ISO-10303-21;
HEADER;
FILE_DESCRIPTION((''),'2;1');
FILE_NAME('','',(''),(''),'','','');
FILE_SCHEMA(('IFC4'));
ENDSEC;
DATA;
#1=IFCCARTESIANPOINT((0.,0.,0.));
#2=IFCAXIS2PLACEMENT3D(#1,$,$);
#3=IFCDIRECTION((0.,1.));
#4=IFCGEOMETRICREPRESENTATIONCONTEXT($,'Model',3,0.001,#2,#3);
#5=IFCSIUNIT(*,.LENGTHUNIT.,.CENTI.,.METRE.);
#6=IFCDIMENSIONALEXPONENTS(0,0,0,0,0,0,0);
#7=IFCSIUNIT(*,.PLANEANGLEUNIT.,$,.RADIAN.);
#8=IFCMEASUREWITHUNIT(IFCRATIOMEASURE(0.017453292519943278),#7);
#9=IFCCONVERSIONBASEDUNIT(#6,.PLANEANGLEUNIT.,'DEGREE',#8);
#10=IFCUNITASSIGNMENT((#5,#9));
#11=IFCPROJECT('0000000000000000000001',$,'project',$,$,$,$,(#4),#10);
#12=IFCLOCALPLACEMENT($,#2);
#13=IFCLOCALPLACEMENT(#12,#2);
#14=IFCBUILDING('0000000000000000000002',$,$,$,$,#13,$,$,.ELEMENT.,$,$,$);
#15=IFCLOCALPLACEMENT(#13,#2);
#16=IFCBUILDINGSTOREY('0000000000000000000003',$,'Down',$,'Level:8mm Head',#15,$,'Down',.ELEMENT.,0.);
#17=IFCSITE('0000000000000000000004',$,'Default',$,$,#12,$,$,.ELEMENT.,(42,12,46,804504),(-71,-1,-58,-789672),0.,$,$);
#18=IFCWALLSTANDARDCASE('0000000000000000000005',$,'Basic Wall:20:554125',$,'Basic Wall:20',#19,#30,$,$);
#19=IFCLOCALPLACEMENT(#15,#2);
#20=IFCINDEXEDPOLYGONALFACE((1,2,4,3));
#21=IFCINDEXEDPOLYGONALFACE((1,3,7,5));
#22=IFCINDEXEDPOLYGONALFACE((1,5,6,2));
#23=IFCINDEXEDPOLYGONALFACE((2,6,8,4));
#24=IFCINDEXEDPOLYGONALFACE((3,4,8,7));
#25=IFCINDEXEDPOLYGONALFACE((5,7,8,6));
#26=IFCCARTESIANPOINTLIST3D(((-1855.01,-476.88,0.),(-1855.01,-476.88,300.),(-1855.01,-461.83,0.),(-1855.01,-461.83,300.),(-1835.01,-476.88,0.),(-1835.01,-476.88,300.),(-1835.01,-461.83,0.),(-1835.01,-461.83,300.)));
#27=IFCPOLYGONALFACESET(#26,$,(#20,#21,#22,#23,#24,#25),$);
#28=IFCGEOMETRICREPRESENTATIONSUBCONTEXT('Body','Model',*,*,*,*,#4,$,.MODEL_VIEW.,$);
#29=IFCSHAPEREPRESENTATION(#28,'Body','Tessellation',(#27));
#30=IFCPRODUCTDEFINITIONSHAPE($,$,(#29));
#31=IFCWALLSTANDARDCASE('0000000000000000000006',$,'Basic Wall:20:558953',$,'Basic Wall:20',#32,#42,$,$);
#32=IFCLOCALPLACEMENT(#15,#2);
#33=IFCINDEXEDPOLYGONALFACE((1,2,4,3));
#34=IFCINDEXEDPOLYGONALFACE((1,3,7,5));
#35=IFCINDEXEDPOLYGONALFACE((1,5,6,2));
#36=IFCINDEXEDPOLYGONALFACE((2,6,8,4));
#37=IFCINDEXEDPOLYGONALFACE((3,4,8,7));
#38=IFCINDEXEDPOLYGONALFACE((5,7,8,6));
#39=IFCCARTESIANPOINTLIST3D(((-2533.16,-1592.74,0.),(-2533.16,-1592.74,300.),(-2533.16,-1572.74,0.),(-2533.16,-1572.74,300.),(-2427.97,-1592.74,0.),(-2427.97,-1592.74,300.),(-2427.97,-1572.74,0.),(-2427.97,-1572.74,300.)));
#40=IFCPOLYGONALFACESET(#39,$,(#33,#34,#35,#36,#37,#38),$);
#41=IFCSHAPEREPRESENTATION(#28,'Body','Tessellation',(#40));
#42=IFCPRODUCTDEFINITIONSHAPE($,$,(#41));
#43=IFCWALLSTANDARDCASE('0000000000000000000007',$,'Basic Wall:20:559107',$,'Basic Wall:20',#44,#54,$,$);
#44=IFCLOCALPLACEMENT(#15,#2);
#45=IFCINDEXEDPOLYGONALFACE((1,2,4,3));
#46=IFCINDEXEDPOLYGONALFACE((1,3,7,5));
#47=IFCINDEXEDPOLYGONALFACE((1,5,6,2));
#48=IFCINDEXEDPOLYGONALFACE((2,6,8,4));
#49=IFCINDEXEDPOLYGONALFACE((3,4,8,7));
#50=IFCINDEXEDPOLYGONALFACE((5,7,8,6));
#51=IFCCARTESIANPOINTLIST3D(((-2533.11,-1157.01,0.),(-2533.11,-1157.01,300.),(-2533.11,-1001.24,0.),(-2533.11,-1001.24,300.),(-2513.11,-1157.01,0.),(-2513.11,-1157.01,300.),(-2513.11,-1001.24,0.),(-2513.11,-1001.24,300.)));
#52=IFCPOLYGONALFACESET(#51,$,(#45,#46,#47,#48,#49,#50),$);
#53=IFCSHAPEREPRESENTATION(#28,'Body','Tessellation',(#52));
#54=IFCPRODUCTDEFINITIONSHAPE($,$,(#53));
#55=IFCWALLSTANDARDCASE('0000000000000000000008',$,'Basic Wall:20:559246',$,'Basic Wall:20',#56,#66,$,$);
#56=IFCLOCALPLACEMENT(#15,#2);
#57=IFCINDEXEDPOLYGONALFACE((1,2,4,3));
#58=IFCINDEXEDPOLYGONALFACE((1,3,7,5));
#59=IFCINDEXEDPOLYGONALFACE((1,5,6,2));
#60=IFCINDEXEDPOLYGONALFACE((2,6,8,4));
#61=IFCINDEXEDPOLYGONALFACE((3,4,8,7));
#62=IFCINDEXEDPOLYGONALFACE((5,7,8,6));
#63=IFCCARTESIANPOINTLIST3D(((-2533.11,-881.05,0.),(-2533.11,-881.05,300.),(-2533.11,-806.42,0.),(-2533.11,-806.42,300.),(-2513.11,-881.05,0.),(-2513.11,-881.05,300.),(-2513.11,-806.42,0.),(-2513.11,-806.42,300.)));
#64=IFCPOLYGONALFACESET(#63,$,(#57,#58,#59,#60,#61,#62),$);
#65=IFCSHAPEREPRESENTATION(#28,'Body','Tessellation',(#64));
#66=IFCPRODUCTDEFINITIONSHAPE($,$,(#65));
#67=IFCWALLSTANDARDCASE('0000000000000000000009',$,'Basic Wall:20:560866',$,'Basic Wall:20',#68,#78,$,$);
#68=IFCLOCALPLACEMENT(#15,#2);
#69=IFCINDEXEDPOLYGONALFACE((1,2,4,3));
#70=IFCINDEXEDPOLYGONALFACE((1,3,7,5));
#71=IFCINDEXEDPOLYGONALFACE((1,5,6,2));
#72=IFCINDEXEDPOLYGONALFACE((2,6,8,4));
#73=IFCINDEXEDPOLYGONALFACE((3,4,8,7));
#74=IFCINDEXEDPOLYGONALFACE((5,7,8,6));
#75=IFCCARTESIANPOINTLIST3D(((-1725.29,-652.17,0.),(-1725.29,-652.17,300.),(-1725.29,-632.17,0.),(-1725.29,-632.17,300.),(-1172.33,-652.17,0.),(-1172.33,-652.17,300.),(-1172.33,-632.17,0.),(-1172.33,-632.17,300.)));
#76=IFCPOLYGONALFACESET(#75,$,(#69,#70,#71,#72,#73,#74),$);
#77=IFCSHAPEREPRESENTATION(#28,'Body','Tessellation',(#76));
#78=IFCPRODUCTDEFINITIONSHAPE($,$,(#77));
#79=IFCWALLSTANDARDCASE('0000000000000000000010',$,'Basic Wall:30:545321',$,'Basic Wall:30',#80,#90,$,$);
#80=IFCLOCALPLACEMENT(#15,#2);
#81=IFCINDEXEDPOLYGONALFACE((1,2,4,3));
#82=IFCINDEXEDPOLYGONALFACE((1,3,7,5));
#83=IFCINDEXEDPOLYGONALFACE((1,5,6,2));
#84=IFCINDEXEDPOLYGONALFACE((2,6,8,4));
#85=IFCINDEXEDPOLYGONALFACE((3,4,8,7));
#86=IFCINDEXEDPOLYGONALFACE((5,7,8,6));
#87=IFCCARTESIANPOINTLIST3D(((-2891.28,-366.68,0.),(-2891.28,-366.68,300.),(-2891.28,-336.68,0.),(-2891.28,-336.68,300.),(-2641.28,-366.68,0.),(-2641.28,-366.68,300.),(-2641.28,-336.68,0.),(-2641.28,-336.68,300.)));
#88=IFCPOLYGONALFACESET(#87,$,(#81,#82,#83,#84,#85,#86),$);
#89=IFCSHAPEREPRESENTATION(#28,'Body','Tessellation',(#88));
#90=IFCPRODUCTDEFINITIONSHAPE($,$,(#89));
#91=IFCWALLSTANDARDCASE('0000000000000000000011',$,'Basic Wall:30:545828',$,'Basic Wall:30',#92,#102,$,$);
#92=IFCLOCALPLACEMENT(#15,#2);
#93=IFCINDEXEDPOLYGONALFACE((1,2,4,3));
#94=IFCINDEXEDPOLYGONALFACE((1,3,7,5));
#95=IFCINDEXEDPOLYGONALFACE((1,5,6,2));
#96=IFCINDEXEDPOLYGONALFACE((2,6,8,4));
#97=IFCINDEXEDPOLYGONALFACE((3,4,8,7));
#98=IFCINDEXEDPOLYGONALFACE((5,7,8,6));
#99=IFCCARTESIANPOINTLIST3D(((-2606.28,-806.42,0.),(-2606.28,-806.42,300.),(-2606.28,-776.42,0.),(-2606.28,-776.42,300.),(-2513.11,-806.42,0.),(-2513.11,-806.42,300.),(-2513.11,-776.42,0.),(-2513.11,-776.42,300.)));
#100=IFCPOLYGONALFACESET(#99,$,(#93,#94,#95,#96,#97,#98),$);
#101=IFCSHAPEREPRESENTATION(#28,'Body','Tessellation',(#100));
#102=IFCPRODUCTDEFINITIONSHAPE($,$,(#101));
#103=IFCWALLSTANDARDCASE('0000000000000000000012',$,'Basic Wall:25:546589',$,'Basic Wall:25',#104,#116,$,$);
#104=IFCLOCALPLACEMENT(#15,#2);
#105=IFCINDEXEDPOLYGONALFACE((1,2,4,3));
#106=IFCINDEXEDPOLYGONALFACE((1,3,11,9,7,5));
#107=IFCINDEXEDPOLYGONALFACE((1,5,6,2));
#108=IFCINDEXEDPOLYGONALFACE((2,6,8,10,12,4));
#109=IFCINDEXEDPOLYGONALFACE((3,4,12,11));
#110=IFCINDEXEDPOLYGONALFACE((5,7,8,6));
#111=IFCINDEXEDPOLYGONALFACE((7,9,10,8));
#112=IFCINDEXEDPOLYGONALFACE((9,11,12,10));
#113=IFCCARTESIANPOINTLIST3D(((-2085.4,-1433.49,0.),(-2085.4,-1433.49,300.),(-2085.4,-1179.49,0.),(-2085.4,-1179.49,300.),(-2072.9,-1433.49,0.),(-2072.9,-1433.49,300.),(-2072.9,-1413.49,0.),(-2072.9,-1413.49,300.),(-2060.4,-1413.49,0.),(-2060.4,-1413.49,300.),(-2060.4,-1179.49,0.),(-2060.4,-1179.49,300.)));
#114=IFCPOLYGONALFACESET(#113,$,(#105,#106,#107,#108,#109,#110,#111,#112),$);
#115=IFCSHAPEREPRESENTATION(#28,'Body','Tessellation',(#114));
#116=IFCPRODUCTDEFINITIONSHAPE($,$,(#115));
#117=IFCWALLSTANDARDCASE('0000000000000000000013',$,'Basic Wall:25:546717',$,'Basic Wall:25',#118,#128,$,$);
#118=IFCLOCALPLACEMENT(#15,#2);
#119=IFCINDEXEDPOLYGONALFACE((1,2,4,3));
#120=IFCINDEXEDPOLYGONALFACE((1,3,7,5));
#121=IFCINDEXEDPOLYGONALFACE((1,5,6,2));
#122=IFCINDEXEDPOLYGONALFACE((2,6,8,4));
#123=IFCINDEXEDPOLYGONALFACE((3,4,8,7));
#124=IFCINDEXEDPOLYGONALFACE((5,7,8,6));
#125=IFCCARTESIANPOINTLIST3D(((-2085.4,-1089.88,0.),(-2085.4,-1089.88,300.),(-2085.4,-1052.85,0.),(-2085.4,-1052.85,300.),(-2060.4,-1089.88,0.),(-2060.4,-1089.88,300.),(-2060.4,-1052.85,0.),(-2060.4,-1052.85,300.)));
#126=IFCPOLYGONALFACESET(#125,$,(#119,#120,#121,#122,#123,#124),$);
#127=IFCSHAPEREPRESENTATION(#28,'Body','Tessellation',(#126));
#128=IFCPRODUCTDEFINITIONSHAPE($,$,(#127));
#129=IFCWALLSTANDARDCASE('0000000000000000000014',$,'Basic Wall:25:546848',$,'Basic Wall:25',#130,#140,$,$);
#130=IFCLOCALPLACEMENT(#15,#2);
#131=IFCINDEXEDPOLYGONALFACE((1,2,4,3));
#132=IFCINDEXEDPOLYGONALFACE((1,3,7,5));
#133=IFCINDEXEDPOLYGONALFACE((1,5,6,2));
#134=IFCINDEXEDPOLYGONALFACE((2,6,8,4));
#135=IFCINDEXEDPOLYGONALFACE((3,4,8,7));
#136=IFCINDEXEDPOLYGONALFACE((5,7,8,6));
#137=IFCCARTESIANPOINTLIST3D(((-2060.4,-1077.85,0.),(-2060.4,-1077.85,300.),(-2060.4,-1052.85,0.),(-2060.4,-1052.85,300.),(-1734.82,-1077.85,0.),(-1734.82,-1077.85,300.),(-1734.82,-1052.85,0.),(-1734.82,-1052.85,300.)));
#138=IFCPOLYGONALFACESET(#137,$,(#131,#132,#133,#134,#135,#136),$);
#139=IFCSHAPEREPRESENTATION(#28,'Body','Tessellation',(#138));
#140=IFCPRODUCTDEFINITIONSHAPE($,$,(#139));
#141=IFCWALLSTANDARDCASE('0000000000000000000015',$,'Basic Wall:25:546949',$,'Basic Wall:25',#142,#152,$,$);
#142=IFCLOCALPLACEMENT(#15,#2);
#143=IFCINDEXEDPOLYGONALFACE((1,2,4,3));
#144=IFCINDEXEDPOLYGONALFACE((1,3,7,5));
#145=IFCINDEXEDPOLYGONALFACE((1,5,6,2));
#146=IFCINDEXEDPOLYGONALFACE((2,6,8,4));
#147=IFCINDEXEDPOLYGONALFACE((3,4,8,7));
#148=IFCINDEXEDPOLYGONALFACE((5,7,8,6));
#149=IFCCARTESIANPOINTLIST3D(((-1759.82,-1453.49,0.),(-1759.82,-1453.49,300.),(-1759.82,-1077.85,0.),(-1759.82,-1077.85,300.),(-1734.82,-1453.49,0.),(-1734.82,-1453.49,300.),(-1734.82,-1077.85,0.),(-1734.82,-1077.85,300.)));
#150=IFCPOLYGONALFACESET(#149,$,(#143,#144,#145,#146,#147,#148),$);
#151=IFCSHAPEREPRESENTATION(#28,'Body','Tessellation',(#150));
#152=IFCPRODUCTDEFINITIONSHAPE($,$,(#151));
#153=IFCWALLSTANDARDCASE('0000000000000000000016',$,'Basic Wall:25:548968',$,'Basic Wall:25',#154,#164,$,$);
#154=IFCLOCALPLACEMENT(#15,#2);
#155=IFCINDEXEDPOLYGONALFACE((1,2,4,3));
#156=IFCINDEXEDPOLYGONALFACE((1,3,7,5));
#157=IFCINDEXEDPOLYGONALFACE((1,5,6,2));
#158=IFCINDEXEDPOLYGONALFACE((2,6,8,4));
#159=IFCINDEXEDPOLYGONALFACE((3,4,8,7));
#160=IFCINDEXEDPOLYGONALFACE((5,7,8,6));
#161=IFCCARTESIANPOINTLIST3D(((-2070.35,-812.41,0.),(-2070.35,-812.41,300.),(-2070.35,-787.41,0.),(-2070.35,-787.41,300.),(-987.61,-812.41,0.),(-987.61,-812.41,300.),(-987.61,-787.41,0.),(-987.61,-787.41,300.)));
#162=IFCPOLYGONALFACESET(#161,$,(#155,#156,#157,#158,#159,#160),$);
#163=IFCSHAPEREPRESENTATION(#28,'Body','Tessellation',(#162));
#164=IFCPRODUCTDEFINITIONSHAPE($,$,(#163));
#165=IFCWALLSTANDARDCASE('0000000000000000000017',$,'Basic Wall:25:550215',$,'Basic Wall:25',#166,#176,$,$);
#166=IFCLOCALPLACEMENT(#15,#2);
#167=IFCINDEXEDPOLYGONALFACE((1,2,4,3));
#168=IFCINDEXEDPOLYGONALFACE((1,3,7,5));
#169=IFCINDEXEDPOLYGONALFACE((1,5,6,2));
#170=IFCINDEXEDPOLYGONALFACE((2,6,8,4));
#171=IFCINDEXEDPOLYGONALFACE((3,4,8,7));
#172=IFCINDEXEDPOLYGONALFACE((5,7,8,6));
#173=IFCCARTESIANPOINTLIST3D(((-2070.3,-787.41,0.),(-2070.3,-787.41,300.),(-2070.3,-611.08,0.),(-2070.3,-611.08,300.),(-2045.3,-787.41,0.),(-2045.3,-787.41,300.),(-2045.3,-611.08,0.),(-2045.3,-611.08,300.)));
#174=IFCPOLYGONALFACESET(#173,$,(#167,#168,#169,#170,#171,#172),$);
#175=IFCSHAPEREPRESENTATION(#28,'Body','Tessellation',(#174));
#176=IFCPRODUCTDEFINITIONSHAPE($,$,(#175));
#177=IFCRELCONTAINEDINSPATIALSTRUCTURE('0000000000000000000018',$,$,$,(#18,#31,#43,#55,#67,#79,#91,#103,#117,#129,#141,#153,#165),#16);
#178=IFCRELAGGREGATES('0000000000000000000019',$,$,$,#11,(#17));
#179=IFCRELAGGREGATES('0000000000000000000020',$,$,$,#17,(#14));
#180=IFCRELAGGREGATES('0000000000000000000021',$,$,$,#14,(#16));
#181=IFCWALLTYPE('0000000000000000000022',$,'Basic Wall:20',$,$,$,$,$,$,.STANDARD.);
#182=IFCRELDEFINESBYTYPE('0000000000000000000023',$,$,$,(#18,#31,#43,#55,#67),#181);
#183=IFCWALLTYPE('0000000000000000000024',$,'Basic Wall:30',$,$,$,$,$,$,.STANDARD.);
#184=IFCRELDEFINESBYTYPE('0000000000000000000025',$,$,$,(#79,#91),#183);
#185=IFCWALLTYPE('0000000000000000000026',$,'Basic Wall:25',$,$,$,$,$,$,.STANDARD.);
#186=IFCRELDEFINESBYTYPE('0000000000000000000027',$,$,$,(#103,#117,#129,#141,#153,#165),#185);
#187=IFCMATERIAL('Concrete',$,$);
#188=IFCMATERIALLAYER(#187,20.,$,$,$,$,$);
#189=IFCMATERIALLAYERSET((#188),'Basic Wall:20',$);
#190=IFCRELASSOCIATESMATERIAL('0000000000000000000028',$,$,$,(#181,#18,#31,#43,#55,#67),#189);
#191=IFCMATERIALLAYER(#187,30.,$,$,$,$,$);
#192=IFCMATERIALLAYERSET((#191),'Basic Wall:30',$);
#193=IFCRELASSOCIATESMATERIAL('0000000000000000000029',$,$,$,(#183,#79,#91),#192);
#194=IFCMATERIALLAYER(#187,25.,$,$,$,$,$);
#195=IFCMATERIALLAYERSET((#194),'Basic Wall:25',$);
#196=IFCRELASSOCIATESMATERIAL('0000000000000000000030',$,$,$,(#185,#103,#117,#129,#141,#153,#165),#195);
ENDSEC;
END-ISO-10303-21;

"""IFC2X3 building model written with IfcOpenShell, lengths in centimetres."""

from ifc_helpers import new_model, entity, si_unit, converted_unit, direction, frame, frame_2d, origin, place, context, subcontext, project, spatial, polyline, rectangle, outline, extrude, material, layer, layer_set, layer_usage, type_object, element, save


model = new_model("IFC2X3")

# Units and contexts
model_context = context("Model", 3, precision=0.001, world=origin(), true_north=direction((0.0, 1.0)))
body_context = subcontext(model_context, "Body", "Model", "MODEL_VIEW")
ifc_project = project(units=[si_unit("LENGTHUNIT", "METRE", prefix="CENTI"), converted_unit("PLANEANGLEUNIT", "DEGREE", entity("IfcRatioMeasure", 0.017453292519943278), si_unit("PLANEANGLEUNIT", "RADIAN"), dimensions=[0, 0, 0, 0, 0, 0, 0])], contexts=[model_context])

# Site, building, storey
site_placement = place(None, origin())
site = spatial("IfcSite", under=ifc_project, at=site_placement, Name="Default", CompositionType="ELEMENT", RefLatitude=(42, 12, 46, 804504), RefLongitude=(-71, -1, -58, -789672), RefElevation=0.0)
building_placement = place(site_placement, origin())
building = spatial("IfcBuilding", under=site, at=building_placement, CompositionType="ELEMENT")
storey_placement = place(building_placement, origin())
storey = spatial("IfcBuildingStorey", under=building, at=storey_placement, Name="Down", ObjectType="Level:8mm Head", LongName="Down", CompositionType="ELEMENT", Elevation=0.0)

# Walls
ifc_material = material(Name="Concrete")
ifc_layer_1 = layer(ifc_material, 20.0)
ifc_layer_set_1 = layer_set([ifc_layer_1], Name="Basic Wall:20")
wall_type_1 = type_object("IfcWallType", Name="Basic Wall:20", PredefinedType="STANDARD", material=ifc_layer_set_1)
ifc_layer_usage_1 = layer_usage(ifc_layer_set_1, "AXIS2", "POSITIVE", -10.0)
wall_1_placement = place(storey_placement, frame((-1845.01, -476.88, 0.0), z_axis=(0.0, 0.0, 1.0), x_axis=(0.0, 1.0, 0.0)))
element("IfcWallStandardCase", 1, at=wall_1_placement, inside=storey, type_object=wall_type_1, material=ifc_layer_usage_1, Name="Basic Wall:20:554125", ObjectType="Basic Wall:20", context=body_context, shape_type="SweptSolid", body=[
    extrude(rectangle(XDim=15.05, YDim=20.0, at=frame_2d((7.53, 0.0), x_axis=(-1.0, 0.0))), origin(), (0.0, 0.0, 1.0), 300.0),
])
ifc_layer_usage_2 = layer_usage(ifc_layer_set_1, "AXIS2", "POSITIVE", -10.0)
wall_2_placement = place(storey_placement, frame((-2533.16, -1582.74, 0.0)))
element("IfcWallStandardCase", 2, at=wall_2_placement, inside=storey, type_object=wall_type_1, material=ifc_layer_usage_2, Name="Basic Wall:20:558953", ObjectType="Basic Wall:20", context=body_context, shape_type="SweptSolid", body=[
    extrude(rectangle(XDim=105.2, YDim=20.0, at=frame_2d((52.6, 0.0), x_axis=(-1.0, 0.0))), origin(), (0.0, 0.0, 1.0), 300.0),
])
ifc_layer_usage_3 = layer_usage(ifc_layer_set_1, "AXIS2", "POSITIVE", -10.0)
wall_3_placement = place(storey_placement, frame((-2523.11, -1157.01, 0.0), z_axis=(0.0, 0.0, 1.0), x_axis=(0.0, 1.0, 0.0)))
element("IfcWallStandardCase", 3, at=wall_3_placement, inside=storey, type_object=wall_type_1, material=ifc_layer_usage_3, Name="Basic Wall:20:559107", ObjectType="Basic Wall:20", context=body_context, shape_type="SweptSolid", body=[
    extrude(rectangle(XDim=155.76, YDim=20.0, at=frame_2d((77.88, 0.0), x_axis=(-1.0, 0.0))), origin(), (0.0, 0.0, 1.0), 300.0),
])
ifc_layer_usage_4 = layer_usage(ifc_layer_set_1, "AXIS2", "POSITIVE", -10.0)
wall_4_placement = place(storey_placement, frame((-2523.11, -881.05, 0.0), z_axis=(0.0, 0.0, 1.0), x_axis=(0.0, 1.0, 0.0)))
element("IfcWallStandardCase", 4, at=wall_4_placement, inside=storey, type_object=wall_type_1, material=ifc_layer_usage_4, Name="Basic Wall:20:559246", ObjectType="Basic Wall:20", context=body_context, shape_type="SweptSolid", body=[
    extrude(rectangle(XDim=74.63, YDim=20.0, at=frame_2d((37.31, 0.0), x_axis=(-1.0, 0.0))), origin(), (0.0, 0.0, 1.0), 300.0),
])
ifc_layer_usage_5 = layer_usage(ifc_layer_set_1, "AXIS2", "POSITIVE", -10.0)
wall_5_placement = place(storey_placement, frame((-1725.29, -642.17, 0.0)))
element("IfcWallStandardCase", 5, at=wall_5_placement, inside=storey, type_object=wall_type_1, material=ifc_layer_usage_5, Name="Basic Wall:20:560866", ObjectType="Basic Wall:20", context=body_context, shape_type="SweptSolid", body=[
    extrude(rectangle(XDim=552.96, YDim=20.0, at=frame_2d((276.48, 0.0), x_axis=(-1.0, 0.0))), origin(), (0.0, 0.0, 1.0), 300.0),
])
ifc_layer_2 = layer(ifc_material, 30.0)
ifc_layer_set_2 = layer_set([ifc_layer_2], Name="Basic Wall:30")
ifc_layer_usage_6 = layer_usage(ifc_layer_set_2, "AXIS2", "POSITIVE", -15.0)
wall_type_2 = type_object("IfcWallType", Name="Basic Wall:30", PredefinedType="STANDARD", material=ifc_layer_set_2)
wall_6_placement = place(storey_placement, frame((-2641.28, -351.68, 0.0), z_axis=(0.0, 0.0, 1.0), x_axis=(-1.0, 0.0, 0.0)))
element("IfcWallStandardCase", 6, at=wall_6_placement, inside=storey, type_object=wall_type_2, material=ifc_layer_usage_6, Name="Basic Wall:30:545321", ObjectType="Basic Wall:30", context=body_context, shape_type="SweptSolid", body=[
    extrude(rectangle(XDim=250.0, YDim=30.0, at=frame_2d((125.0, 0.0), x_axis=(-1.0, 0.0))), origin(), (0.0, 0.0, 1.0), 300.0),
])
ifc_layer_usage_7 = layer_usage(ifc_layer_set_2, "AXIS2", "POSITIVE", -15.0)
wall_7_placement = place(storey_placement, frame((-2606.28, -791.42, 0.0)))
element("IfcWallStandardCase", 7, at=wall_7_placement, inside=storey, type_object=wall_type_2, material=ifc_layer_usage_7, Name="Basic Wall:30:545828", ObjectType="Basic Wall:30", context=body_context, shape_type="SweptSolid", body=[
    extrude(rectangle(XDim=93.17, YDim=30.0, at=frame_2d((46.58, 0.0), x_axis=(-1.0, 0.0))), origin(), (0.0, 0.0, 1.0), 300.0),
])
ifc_layer_3 = layer(ifc_material, 25.0)
ifc_layer_set_3 = layer_set([ifc_layer_3], Name="Basic Wall:25")
ifc_layer_usage_8 = layer_usage(ifc_layer_set_3, "AXIS2", "NEGATIVE", 12.5)
wall_type_3 = type_object("IfcWallType", Name="Basic Wall:25", PredefinedType="STANDARD", material=ifc_layer_set_3)
wall_8_placement = place(storey_placement, frame((-2072.9, -1433.49, 0.0), z_axis=(0.0, 0.0, 1.0), x_axis=(0.0, 1.0, 0.0)))
element("IfcWallStandardCase", 8, at=wall_8_placement, inside=storey, type_object=wall_type_3, material=ifc_layer_usage_8, Name="Basic Wall:25:546589", ObjectType="Basic Wall:25", context=body_context, shape_type="SweptSolid", body=[
    extrude(outline(polyline([(254.0, -12.5), (254.0, 12.5), (0.0, 12.5), (0.0, 0.0), (20.0, 0.0), (20.0, -12.5), (254.0, -12.5)])), origin(), (0.0, 0.0, 1.0), 300.0),
])
ifc_layer_usage_9 = layer_usage(ifc_layer_set_3, "AXIS2", "NEGATIVE", 12.5)
wall_9_placement = place(storey_placement, frame((-2072.9, -1089.88, 0.0), z_axis=(0.0, 0.0, 1.0), x_axis=(0.0, 1.0, 0.0)))
element("IfcWallStandardCase", 9, at=wall_9_placement, inside=storey, type_object=wall_type_3, material=ifc_layer_usage_9, Name="Basic Wall:25:546717", ObjectType="Basic Wall:25", context=body_context, shape_type="SweptSolid", body=[
    extrude(rectangle(XDim=37.03, YDim=25.0, at=frame_2d((18.51, 0.0), x_axis=(-1.0, 0.0))), origin(), (0.0, 0.0, 1.0), 300.0),
])
ifc_layer_usage_10 = layer_usage(ifc_layer_set_3, "AXIS2", "NEGATIVE", 12.5)
wall_10_placement = place(storey_placement, frame((-2060.4, -1065.35, 0.0)))
element("IfcWallStandardCase", 10, at=wall_10_placement, inside=storey, type_object=wall_type_3, material=ifc_layer_usage_10, Name="Basic Wall:25:546848", ObjectType="Basic Wall:25", context=body_context, shape_type="SweptSolid", body=[
    extrude(rectangle(XDim=325.59, YDim=25.0, at=frame_2d((162.79, 0.0), x_axis=(-1.0, 0.0))), origin(), (0.0, 0.0, 1.0), 300.0),
])
ifc_layer_usage_11 = layer_usage(ifc_layer_set_3, "AXIS2", "NEGATIVE", 12.5)
wall_11_placement = place(storey_placement, frame((-1747.32, -1077.85, 0.0), z_axis=(0.0, 0.0, 1.0), x_axis=(0.0, -1.0, 0.0)))
element("IfcWallStandardCase", 11, at=wall_11_placement, inside=storey, type_object=wall_type_3, material=ifc_layer_usage_11, Name="Basic Wall:25:546949", ObjectType="Basic Wall:25", context=body_context, shape_type="SweptSolid", body=[
    extrude(rectangle(XDim=375.63, YDim=25.0, at=frame_2d((187.82, 0.0), x_axis=(-1.0, 0.0))), origin(), (0.0, 0.0, 1.0), 300.0),
])
ifc_layer_usage_12 = layer_usage(ifc_layer_set_3, "AXIS2", "POSITIVE", -12.5)
wall_12_placement = place(storey_placement, frame((-2070.35, -799.91, 0.0)))
element("IfcWallStandardCase", 12, at=wall_12_placement, inside=storey, type_object=wall_type_3, material=ifc_layer_usage_12, Name="Basic Wall:25:548968", ObjectType="Basic Wall:25", context=body_context, shape_type="SweptSolid", body=[
    extrude(rectangle(XDim=1082.74, YDim=25.0, at=frame_2d((541.37, 0.0), x_axis=(-1.0, 0.0))), origin(), (0.0, 0.0, 1.0), 300.0),
])
ifc_layer_usage_13 = layer_usage(ifc_layer_set_3, "AXIS2", "NEGATIVE", 12.5)
wall_13_placement = place(storey_placement, frame((-2057.8, -611.08, 0.0), z_axis=(0.0, 0.0, 1.0), x_axis=(0.0, -1.0, 0.0)))
element("IfcWallStandardCase", 13, at=wall_13_placement, inside=storey, type_object=wall_type_3, material=ifc_layer_usage_13, Name="Basic Wall:25:550215", ObjectType="Basic Wall:25", context=body_context, shape_type="SweptSolid", body=[
    extrude(rectangle(XDim=176.33, YDim=25.0, at=frame_2d((88.17, 0.0), x_axis=(-1.0, 0.0))), origin(), (0.0, 0.0, 1.0), 300.0),
])

save(model, "model.ifc")
